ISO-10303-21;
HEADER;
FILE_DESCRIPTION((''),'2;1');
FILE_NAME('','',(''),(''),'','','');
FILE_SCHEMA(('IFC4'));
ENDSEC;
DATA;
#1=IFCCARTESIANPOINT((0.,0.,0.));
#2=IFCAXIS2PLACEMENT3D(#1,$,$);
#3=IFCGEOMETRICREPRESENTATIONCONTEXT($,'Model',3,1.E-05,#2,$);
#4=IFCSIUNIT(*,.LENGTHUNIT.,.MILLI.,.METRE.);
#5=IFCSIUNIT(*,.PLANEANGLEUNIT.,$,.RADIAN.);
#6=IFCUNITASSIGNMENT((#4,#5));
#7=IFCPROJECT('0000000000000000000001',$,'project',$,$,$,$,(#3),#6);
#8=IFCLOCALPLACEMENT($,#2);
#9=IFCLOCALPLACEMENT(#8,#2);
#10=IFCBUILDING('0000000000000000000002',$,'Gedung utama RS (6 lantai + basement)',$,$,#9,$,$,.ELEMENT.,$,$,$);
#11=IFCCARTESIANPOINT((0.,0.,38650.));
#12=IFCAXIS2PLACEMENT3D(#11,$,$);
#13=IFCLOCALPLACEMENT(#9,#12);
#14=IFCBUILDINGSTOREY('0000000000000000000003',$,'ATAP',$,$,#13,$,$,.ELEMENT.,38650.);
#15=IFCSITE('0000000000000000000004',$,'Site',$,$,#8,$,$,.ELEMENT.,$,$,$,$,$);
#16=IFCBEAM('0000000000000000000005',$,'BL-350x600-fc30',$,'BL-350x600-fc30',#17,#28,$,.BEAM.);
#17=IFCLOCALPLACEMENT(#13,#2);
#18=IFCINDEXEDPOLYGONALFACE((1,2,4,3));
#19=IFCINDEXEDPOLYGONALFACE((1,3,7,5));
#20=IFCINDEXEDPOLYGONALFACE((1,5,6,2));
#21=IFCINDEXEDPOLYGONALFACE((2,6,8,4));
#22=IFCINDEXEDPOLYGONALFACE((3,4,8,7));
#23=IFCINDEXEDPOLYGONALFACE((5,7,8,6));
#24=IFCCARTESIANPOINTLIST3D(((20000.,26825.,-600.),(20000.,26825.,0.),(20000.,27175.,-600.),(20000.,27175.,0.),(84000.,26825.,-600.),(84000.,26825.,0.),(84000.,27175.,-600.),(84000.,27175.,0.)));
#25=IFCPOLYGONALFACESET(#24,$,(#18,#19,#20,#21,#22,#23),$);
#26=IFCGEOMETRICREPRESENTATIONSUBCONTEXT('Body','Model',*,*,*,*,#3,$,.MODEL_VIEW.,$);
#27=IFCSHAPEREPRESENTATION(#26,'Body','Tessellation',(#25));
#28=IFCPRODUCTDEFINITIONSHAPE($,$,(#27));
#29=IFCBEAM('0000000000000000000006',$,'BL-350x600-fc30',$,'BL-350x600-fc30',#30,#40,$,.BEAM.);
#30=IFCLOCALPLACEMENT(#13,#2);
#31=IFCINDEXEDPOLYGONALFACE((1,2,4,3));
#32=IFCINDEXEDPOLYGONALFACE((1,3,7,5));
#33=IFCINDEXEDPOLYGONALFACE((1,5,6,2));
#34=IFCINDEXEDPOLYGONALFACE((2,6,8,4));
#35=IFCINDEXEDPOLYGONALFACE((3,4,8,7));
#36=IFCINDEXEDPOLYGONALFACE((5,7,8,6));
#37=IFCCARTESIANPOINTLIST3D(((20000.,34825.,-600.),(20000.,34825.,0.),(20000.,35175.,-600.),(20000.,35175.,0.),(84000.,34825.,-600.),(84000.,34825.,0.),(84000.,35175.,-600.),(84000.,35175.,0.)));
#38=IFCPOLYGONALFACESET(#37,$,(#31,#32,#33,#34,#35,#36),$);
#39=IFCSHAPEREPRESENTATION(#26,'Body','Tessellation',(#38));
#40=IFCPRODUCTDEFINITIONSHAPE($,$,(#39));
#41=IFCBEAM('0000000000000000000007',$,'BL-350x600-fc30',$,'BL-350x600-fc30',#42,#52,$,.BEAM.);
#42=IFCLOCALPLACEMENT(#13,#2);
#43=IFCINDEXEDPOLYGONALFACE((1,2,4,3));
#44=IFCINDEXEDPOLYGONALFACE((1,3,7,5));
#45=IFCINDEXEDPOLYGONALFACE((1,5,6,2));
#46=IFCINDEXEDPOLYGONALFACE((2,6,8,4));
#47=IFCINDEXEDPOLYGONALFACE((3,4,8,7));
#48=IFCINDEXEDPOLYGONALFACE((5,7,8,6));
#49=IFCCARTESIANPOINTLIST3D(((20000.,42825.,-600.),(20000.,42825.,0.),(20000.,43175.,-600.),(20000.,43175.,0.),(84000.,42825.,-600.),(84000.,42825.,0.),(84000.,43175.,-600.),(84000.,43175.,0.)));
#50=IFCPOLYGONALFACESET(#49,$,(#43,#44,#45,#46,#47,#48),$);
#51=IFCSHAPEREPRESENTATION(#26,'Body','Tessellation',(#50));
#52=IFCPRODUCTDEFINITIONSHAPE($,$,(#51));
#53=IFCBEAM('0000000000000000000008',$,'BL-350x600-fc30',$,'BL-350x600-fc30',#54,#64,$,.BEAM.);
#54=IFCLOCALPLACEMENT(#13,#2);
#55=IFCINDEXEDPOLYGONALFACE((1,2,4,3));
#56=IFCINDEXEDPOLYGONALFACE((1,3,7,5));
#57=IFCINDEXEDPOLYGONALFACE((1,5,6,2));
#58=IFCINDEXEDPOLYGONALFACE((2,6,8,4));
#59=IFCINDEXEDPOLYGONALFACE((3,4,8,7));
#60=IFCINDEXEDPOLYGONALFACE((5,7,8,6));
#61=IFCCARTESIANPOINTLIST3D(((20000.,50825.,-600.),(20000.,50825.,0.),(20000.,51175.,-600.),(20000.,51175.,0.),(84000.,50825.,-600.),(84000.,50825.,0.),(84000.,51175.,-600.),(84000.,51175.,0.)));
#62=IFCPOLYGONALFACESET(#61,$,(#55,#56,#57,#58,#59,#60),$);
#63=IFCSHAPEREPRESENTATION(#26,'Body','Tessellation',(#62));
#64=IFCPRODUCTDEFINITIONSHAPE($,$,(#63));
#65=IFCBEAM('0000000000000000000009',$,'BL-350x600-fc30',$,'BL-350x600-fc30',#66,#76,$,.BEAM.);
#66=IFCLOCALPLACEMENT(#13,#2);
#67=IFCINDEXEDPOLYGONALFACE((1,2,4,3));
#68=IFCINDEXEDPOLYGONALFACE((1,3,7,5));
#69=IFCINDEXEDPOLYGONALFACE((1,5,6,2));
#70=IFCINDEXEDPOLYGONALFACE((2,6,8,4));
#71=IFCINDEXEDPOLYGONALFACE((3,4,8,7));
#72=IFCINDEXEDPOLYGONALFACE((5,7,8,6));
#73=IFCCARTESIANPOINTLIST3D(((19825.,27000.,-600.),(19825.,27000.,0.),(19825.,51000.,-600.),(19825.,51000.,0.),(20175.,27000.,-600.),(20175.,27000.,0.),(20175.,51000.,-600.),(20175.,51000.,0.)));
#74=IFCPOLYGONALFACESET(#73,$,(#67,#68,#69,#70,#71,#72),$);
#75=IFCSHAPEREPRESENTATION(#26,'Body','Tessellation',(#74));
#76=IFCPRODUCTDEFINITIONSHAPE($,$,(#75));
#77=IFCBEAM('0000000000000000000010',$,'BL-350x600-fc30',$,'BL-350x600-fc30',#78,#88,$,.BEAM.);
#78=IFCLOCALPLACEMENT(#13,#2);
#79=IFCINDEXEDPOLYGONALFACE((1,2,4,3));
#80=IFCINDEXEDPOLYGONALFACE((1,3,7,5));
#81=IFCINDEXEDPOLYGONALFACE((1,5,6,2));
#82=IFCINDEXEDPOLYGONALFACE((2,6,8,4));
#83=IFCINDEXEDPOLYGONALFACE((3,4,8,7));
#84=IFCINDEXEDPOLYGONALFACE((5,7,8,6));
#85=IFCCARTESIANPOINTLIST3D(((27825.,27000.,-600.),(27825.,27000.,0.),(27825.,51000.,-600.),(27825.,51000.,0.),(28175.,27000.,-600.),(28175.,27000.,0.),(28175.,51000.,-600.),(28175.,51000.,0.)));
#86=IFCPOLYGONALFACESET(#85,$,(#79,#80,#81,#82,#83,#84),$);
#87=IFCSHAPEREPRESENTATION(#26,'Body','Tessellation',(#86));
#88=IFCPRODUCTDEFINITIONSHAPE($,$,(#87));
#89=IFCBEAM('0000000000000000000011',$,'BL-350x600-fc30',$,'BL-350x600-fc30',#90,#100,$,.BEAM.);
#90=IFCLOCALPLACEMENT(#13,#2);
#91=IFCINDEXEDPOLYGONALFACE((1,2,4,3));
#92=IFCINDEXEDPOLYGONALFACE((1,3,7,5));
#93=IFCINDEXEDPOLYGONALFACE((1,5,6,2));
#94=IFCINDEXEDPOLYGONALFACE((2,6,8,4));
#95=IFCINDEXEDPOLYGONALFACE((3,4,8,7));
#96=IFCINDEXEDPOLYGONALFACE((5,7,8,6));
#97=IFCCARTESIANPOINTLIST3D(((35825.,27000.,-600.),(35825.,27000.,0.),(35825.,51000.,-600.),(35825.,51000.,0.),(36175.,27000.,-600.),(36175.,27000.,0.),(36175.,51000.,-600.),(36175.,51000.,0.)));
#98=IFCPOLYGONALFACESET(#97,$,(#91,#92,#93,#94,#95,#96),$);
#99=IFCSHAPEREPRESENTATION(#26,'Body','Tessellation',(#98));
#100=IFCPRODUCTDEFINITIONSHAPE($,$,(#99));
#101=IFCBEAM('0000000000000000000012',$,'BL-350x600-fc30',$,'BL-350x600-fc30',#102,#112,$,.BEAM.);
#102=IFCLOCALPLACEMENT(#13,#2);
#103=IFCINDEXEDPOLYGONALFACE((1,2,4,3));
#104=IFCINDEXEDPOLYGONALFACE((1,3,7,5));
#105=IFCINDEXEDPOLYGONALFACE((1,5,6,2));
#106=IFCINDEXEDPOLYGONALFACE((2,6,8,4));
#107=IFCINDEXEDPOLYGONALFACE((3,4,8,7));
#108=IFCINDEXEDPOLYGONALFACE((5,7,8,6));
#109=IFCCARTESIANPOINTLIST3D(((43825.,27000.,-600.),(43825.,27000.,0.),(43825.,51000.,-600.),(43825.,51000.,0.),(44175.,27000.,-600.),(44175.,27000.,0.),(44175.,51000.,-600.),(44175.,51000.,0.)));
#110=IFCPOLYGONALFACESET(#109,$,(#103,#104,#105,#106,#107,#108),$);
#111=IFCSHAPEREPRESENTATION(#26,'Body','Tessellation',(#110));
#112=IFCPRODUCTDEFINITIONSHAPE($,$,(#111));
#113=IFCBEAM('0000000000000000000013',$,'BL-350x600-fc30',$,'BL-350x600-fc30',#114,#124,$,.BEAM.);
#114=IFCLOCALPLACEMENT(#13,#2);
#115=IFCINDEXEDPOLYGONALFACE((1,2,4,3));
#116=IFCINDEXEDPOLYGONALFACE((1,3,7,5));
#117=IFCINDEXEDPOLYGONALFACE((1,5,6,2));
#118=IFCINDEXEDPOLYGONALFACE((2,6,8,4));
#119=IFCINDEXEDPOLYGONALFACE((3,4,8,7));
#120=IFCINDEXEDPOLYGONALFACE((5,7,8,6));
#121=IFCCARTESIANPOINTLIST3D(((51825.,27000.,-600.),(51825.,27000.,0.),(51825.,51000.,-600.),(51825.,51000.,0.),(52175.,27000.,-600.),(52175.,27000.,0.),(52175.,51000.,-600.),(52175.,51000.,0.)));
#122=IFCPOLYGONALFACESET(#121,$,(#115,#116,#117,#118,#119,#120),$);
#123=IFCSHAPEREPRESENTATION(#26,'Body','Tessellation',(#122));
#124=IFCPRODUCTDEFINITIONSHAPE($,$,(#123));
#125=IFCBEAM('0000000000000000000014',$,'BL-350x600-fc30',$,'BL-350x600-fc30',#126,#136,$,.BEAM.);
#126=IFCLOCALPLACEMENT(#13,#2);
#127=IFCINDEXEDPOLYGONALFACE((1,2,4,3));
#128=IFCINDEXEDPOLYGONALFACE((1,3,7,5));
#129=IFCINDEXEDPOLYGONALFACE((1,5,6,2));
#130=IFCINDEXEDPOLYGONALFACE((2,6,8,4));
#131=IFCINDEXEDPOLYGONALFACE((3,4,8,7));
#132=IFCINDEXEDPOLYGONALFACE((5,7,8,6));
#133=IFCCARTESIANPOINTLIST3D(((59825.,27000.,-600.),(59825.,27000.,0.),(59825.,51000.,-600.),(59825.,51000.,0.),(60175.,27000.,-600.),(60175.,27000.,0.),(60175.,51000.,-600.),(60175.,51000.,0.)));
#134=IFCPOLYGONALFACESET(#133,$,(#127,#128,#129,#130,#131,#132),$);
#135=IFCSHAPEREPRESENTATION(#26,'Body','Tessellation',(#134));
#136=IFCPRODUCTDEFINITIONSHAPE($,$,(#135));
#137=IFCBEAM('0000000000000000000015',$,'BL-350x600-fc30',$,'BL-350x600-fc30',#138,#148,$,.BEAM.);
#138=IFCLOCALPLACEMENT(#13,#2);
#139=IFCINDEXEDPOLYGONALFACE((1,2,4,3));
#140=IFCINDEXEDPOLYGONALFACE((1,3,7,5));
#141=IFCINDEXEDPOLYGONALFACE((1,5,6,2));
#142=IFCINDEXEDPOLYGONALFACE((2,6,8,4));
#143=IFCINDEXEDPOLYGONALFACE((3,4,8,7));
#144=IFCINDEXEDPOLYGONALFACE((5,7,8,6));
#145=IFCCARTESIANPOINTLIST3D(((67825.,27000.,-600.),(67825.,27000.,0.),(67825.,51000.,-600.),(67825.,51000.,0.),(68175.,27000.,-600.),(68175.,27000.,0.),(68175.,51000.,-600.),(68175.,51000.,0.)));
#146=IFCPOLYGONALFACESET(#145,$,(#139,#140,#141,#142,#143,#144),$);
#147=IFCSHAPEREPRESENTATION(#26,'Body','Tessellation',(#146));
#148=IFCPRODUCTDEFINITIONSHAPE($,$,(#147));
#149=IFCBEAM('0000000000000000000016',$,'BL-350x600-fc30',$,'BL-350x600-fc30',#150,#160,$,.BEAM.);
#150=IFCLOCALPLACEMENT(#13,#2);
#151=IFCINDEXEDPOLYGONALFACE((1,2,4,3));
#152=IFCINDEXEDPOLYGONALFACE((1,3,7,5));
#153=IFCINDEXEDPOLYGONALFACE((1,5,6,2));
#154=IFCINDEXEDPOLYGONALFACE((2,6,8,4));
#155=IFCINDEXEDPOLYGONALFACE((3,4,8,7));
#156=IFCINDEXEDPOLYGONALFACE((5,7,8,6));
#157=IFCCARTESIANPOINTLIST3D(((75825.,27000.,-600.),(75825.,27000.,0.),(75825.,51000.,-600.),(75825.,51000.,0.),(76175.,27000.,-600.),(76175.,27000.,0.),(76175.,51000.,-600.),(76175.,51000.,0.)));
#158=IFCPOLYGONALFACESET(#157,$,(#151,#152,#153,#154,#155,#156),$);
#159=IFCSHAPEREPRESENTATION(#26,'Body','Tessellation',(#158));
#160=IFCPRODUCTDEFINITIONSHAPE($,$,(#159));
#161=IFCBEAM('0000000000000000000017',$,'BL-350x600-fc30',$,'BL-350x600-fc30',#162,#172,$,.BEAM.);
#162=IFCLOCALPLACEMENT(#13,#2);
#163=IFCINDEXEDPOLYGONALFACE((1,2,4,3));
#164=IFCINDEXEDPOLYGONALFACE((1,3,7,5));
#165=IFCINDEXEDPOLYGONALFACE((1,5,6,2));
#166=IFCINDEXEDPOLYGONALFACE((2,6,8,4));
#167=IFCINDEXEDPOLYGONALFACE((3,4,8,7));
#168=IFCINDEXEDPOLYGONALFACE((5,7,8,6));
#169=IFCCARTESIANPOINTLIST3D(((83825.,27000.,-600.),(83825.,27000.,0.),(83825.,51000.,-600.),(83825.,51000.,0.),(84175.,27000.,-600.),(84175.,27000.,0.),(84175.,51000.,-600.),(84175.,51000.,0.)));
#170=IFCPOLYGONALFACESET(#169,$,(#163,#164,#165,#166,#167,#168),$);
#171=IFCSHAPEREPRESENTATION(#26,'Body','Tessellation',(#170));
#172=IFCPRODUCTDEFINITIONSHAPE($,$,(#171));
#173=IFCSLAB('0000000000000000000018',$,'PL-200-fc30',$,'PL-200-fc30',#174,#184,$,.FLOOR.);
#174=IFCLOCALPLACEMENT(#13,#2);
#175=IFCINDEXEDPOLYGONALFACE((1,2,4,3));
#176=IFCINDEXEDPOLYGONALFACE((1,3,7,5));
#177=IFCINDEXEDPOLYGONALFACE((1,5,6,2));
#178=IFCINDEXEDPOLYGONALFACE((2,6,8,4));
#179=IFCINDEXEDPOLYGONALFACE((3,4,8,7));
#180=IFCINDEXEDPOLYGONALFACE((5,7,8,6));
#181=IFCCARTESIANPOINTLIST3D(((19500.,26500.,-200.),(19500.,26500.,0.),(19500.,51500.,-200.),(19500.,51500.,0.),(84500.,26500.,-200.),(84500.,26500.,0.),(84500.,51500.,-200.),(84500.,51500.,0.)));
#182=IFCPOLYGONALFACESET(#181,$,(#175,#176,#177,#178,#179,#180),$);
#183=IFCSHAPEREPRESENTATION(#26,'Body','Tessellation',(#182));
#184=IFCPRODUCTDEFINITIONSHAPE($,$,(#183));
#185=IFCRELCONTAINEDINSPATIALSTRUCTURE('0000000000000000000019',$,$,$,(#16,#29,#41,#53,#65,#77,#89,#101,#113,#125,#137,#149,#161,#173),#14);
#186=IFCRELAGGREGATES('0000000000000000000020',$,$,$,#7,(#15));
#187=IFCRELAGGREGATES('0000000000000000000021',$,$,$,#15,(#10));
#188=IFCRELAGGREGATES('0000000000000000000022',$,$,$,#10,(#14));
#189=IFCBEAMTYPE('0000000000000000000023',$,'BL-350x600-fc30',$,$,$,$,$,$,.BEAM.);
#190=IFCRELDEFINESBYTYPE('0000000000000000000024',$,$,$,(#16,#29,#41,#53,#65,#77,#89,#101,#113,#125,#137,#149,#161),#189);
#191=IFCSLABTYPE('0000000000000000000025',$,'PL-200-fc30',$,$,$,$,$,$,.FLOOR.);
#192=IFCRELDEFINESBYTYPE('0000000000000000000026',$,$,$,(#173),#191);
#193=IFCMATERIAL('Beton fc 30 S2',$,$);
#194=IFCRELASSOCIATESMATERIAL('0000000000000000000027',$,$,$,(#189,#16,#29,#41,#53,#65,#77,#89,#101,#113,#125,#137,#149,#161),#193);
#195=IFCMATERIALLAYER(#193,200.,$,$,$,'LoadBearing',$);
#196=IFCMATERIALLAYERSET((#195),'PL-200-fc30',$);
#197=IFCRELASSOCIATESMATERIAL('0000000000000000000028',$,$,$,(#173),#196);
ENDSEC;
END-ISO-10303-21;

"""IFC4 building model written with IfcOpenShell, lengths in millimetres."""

from ifc_helpers import new_model, si_unit, frame, origin, origin_2d, place, context, subcontext, project, spatial, polyline, rectangle, outline, extrude, material, layer, layer_set, layer_usage, material_profile, profile_set, profile_usage, type_object, element, save


model = new_model("IFC4")

# Units and contexts
model_context = context("Model", 3, precision=1e-05, world=origin())
body_context = subcontext(model_context, "Body", "Model", "MODEL_VIEW")
ifc_project = project(units=[si_unit("LENGTHUNIT", "METRE", prefix="MILLI"), si_unit("PLANEANGLEUNIT", "RADIAN")], contexts=[model_context])

# Site, building, storey
site_placement = place(None, origin())
site = spatial("IfcSite", under=ifc_project, at=site_placement, Name="Site", CompositionType="ELEMENT")
building_placement = place(site_placement, origin())
building = spatial("IfcBuilding", under=site, at=building_placement, Name="Gedung utama RS (6 lantai + basement)", CompositionType="ELEMENT")
storey_placement = place(building_placement, frame((0.0, 0.0, 38650.0)))
storey = spatial("IfcBuildingStorey", under=building, at=storey_placement, Name="ATAP", CompositionType="ELEMENT", Elevation=38650.0)

# Beams
ifc_material = material(Name="Beton fc 30 S2")
ifc_material_profile = material_profile(ifc_material, rectangle(XDim=350.0, YDim=600.0, at=origin_2d()), Name="BL-350x600-fc30")
ifc_profile_set = profile_set([ifc_material_profile], Name="BL-350x600-fc30")
ifc_profile_usage = profile_usage(ifc_profile_set, cardinal=8)
beam_type = type_object("IfcBeamType", Name="BL-350x600-fc30", PredefinedType="BEAM", material=ifc_profile_set)
for number, where, name in (
    (1, (20000.0, 27000.0, -300.0), "BL-350x600-fc30"),
    (2, (20000.0, 35000.0, -300.0), "BL-350x600-fc30"),
    (3, (20000.0, 43000.0, -300.0), "BL-350x600-fc30"),
    (4, (20000.0, 51000.0, -300.0), "BL-350x600-fc30"),
):
    element("IfcBeam", number, at=place(storey_placement, frame(where)), inside=storey, type_object=beam_type, material=ifc_profile_usage, Name=name, ObjectType="BL-350x600-fc30", PredefinedType="BEAM", context=body_context, shape_type="SweptSolid", body=[
        extrude(rectangle(XDim=350.0, YDim=600.0, at=origin_2d()), frame((0.0, 0.0, 0.0), z_axis=(1.0, 0.0, 0.0), x_axis=(0.0, 1.0, 0.0)), (0.0, 0.0, 1.0), 64000.0),
    ])
for number, where, name in (
    (5, (20000.0, 27000.0, -300.0), "BL-350x600-fc30"),
    (6, (28000.0, 27000.0, -300.0), "BL-350x600-fc30"),
    (7, (36000.0, 27000.0, -300.0), "BL-350x600-fc30"),
    (8, (44000.0, 27000.0, -300.0), "BL-350x600-fc30"),
    (9, (52000.0, 27000.0, -300.0), "BL-350x600-fc30"),
    (10, (60000.0, 27000.0, -300.0), "BL-350x600-fc30"),
    (11, (68000.0, 27000.0, -300.0), "BL-350x600-fc30"),
    (12, (76000.0, 27000.0, -300.0), "BL-350x600-fc30"),
    (13, (84000.0, 27000.0, -300.0), "BL-350x600-fc30"),
):
    element("IfcBeam", number, at=place(storey_placement, frame(where)), inside=storey, type_object=beam_type, material=ifc_profile_usage, Name=name, ObjectType="BL-350x600-fc30", PredefinedType="BEAM", context=body_context, shape_type="SweptSolid", body=[
        extrude(rectangle(XDim=350.0, YDim=600.0, at=origin_2d()), frame((0.0, 0.0, 0.0), z_axis=(0.0, 1.0, 0.0), x_axis=(-1.0, 0.0, 0.0)), (0.0, 0.0, 1.0), 24000.0),
    ])

# Slab
ifc_layer = layer(ifc_material, 200.0, Category="LoadBearing")
ifc_layer_set = layer_set([ifc_layer], Name="PL-200-fc30")
ifc_layer_usage = layer_usage(ifc_layer_set, "AXIS3", "NEGATIVE", 0.0)
slab_type = type_object("IfcSlabType", Name="PL-200-fc30", PredefinedType="FLOOR")
slab_placement = place(storey_placement, origin())
element("IfcSlab", 14, at=slab_placement, inside=storey, type_object=slab_type, material=ifc_layer_usage, Name="PL-200-fc30", ObjectType="PL-200-fc30", PredefinedType="FLOOR", context=body_context, shape_type="SweptSolid", body=[
    extrude(outline(polyline([(19500.0, 26500.0), (84500.0, 26500.0), (84500.0, 51500.0), (19500.0, 51500.0), (19500.0, 26500.0)])), frame((0.0, 0.0, -200.0)), (0.0, 0.0, 1.0), 200.0),
])

save(model, "model.ifc")
